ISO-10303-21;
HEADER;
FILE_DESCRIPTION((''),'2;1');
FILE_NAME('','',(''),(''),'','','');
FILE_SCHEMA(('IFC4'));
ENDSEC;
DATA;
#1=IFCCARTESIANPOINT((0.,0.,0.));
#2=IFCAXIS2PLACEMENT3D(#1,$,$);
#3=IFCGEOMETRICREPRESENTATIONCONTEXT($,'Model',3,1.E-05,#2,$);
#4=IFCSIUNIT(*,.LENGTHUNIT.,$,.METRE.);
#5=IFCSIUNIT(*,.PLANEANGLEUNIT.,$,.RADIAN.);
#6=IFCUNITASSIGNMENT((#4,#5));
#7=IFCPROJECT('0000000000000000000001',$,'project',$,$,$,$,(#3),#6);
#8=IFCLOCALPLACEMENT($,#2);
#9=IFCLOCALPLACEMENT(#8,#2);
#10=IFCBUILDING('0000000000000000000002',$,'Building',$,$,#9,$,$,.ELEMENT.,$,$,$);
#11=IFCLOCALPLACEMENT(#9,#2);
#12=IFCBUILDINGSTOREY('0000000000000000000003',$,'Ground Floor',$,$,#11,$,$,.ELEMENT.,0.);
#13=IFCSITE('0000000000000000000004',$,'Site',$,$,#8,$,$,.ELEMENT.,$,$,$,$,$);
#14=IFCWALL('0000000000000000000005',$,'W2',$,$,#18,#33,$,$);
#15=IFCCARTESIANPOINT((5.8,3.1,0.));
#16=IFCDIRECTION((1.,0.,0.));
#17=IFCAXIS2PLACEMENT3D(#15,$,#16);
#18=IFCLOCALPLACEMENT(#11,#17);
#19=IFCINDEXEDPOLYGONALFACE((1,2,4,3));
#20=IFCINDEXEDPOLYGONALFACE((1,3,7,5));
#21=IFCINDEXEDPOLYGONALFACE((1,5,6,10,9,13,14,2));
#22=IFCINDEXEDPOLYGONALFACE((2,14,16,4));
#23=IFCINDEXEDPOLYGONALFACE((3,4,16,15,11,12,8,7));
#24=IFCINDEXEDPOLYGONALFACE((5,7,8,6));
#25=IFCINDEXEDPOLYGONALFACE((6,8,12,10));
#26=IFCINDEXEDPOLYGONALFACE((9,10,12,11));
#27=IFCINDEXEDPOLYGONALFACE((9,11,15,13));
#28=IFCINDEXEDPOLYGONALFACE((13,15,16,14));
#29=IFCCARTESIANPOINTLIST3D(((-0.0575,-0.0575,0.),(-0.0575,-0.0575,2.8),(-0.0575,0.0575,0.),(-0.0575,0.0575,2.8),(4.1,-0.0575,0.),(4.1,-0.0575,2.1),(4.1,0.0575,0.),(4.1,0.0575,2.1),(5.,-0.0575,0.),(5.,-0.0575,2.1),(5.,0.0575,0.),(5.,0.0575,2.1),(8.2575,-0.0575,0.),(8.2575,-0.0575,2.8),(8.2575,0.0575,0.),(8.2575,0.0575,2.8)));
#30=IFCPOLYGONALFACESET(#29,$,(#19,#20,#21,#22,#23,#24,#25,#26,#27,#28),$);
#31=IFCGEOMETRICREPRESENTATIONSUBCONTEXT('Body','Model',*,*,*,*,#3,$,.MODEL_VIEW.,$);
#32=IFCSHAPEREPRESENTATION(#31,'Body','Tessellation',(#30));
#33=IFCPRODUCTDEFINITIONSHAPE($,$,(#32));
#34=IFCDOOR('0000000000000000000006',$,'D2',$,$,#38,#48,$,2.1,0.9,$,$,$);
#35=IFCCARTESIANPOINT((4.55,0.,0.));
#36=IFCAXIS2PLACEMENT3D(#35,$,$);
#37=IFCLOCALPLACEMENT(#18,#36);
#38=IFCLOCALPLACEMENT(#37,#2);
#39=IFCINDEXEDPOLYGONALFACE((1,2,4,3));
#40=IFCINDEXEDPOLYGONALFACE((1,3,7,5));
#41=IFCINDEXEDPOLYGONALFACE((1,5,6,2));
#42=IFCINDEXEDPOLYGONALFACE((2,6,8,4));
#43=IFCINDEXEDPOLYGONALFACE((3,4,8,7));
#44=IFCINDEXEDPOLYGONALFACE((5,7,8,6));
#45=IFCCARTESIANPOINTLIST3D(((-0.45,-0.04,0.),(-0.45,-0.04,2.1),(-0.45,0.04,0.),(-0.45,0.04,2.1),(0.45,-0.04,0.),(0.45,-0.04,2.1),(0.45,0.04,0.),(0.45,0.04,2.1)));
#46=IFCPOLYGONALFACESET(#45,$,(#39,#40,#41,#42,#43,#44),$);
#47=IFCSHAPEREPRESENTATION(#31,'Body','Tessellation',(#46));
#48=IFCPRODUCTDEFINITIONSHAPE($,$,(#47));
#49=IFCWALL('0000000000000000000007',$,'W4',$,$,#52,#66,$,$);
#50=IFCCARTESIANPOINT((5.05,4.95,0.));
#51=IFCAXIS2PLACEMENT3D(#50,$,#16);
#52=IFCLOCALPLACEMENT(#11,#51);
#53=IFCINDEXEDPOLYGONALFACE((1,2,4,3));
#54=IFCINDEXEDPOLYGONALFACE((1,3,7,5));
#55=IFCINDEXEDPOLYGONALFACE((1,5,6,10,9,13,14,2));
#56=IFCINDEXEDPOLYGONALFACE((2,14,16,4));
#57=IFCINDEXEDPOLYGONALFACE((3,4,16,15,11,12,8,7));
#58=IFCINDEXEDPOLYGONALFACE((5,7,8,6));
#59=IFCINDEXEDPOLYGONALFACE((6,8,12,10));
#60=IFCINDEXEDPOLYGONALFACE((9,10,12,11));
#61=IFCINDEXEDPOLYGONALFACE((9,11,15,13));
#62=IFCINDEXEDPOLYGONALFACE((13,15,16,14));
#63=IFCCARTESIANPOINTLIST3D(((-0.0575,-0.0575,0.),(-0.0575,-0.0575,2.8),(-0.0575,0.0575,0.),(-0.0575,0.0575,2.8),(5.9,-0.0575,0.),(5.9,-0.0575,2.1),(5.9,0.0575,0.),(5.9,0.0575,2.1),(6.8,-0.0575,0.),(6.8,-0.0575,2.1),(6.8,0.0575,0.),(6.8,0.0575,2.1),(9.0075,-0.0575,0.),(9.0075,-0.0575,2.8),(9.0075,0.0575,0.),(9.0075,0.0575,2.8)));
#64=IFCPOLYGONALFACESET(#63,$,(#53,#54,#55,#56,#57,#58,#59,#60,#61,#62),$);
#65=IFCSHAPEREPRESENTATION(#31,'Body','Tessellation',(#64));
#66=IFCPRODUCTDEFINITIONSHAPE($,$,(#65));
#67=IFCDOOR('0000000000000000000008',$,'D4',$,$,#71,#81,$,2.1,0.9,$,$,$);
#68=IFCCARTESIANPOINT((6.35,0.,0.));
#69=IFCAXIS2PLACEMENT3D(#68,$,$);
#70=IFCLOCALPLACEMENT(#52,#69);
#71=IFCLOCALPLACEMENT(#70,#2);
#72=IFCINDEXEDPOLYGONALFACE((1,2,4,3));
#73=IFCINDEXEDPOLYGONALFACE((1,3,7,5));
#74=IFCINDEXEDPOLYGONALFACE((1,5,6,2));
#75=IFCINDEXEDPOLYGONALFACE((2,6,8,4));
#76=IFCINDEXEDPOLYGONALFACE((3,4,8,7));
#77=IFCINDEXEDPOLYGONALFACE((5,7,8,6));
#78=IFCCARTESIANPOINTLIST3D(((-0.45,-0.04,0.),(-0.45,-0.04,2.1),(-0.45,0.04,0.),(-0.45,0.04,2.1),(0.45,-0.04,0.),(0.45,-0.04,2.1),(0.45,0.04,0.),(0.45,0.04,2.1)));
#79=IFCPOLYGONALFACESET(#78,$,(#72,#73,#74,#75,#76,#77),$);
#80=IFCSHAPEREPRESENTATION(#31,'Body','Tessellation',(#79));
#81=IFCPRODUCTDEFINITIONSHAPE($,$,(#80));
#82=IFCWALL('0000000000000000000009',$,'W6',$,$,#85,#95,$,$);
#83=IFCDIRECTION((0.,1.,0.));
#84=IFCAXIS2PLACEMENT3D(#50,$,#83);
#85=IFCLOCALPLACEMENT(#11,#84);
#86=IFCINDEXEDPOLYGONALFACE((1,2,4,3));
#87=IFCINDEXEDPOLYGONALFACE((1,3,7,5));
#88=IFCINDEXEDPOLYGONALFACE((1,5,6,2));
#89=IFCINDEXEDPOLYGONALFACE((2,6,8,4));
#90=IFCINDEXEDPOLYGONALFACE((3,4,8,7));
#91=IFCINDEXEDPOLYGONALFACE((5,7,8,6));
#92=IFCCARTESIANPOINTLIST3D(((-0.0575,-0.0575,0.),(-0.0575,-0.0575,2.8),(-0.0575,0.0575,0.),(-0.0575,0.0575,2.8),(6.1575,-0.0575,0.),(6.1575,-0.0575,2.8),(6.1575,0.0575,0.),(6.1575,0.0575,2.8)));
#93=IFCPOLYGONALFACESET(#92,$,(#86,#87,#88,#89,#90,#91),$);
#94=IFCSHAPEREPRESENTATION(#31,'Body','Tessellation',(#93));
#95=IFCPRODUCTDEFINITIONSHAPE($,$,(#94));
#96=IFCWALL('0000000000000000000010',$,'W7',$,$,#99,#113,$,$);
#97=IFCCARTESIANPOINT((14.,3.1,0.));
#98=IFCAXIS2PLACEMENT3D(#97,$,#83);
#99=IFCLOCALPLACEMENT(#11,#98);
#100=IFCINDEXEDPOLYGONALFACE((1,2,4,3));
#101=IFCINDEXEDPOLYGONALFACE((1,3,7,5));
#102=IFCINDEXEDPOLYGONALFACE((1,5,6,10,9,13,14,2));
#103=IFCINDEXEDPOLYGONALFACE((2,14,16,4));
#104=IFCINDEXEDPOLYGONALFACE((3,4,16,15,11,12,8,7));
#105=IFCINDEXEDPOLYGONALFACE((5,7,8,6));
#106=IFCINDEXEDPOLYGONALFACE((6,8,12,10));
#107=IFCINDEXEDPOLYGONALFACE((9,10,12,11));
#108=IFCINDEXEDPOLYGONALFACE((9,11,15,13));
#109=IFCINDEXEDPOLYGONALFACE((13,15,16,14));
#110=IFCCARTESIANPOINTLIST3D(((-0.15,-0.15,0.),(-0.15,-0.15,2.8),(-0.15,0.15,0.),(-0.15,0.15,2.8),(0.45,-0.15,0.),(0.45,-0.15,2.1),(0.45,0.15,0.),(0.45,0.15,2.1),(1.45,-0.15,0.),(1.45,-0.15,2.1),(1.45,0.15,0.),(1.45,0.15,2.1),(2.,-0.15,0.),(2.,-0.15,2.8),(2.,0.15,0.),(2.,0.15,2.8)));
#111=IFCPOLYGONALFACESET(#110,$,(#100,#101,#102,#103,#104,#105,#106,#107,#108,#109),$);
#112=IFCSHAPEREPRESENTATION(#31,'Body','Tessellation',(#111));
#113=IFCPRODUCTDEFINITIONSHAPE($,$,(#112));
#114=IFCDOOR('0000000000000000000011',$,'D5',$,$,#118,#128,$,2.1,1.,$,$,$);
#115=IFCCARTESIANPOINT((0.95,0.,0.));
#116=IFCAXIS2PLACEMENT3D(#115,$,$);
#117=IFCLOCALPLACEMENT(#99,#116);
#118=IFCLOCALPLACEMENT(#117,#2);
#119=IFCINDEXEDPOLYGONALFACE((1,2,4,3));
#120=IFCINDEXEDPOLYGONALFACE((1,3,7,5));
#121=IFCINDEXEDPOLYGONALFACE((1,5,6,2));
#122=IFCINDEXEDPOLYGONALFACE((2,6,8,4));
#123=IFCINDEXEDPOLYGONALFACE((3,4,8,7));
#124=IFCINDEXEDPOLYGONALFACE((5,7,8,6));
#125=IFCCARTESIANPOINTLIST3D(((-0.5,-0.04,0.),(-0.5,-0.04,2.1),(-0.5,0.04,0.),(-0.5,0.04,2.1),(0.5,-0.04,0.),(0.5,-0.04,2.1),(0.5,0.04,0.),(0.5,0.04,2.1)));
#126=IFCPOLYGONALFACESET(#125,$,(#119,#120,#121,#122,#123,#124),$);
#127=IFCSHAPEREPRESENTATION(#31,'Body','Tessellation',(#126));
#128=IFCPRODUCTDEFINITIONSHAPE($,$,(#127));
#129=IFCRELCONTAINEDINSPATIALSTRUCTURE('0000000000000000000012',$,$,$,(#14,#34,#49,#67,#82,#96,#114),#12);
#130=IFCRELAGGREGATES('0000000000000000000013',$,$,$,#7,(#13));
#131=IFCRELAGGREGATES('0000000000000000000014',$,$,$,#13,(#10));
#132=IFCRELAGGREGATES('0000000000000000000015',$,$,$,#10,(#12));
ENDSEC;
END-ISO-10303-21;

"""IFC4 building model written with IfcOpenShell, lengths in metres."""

from ifc_helpers import new_model, si_unit, frame, frame_2d, origin, origin_2d, place, context, subcontext, project, spatial, rectangle, extrude, element, fill, save


model = new_model("IFC4")

# Units and contexts
model_context = context("Model", 3, precision=1e-05, world=origin())
body_context = subcontext(model_context, "Body", "Model", "MODEL_VIEW")
ifc_project = project(units=[si_unit("LENGTHUNIT", "METRE"), si_unit("PLANEANGLEUNIT", "RADIAN")], contexts=[model_context])

# Site, building, storey
site_placement = place(None, origin())
site = spatial("IfcSite", under=ifc_project, at=site_placement, Name="Site", CompositionType="ELEMENT")
building_placement = place(site_placement, origin())
building = spatial("IfcBuilding", under=site, at=building_placement, Name="Building", CompositionType="ELEMENT")
storey_placement = place(building_placement, origin())
storey = spatial("IfcBuildingStorey", under=building, at=storey_placement, Name="Ground Floor", CompositionType="ELEMENT", Elevation=0.0)

# Walls, openings, doors
wall_1_placement = place(storey_placement, frame((5.8, 3.1, 0.0), x_axis=(1.0, 0.0, 0.0)))
wall_1 = element("IfcWall", 1, at=wall_1_placement, inside=storey, Name="W2", context=body_context, shape_type="SweptSolid", body=[
    extrude(rectangle(XDim=8.315, YDim=0.115, at=frame_2d((4.1, 0.0))), origin(), (0.0, 0.0, 1.0), 2.8),
])
opening_1_placement = place(wall_1_placement, frame((4.55, 0.0, 0.0)))
opening_1 = element("IfcOpeningElement", 2, at=opening_1_placement, cuts=wall_1, context=body_context, shape_type="SweptSolid", body=[
    extrude(rectangle(XDim=0.9, YDim=0.215, at=origin_2d()), origin(), (0.0, 0.0, 1.0), 2.1),
])
door_1_placement = place(opening_1_placement, origin())
door_1 = element("IfcDoor", 3, at=door_1_placement, inside=storey, Name="D2", OverallHeight=2.1, OverallWidth=0.9, context=body_context, shape_type="SweptSolid", body=[
    extrude(rectangle(XDim=0.9, YDim=0.08, at=origin_2d()), origin(), (0.0, 0.0, 1.0), 2.1),
])
fill(opening_1, door_1)
wall_2_placement = place(storey_placement, frame((5.05, 4.95, 0.0), x_axis=(1.0, 0.0, 0.0)))
wall_2 = element("IfcWall", 4, at=wall_2_placement, inside=storey, Name="W4", context=body_context, shape_type="SweptSolid", body=[
    extrude(rectangle(XDim=9.065, YDim=0.115, at=frame_2d((4.475, 0.0))), origin(), (0.0, 0.0, 1.0), 2.8),
])
opening_2_placement = place(wall_2_placement, frame((6.35, 0.0, 0.0)))
opening_2 = element("IfcOpeningElement", 5, at=opening_2_placement, cuts=wall_2, context=body_context, shape_type="SweptSolid", body=[
    extrude(rectangle(XDim=0.9, YDim=0.215, at=origin_2d()), origin(), (0.0, 0.0, 1.0), 2.1),
])
door_2_placement = place(opening_2_placement, origin())
door_2 = element("IfcDoor", 6, at=door_2_placement, inside=storey, Name="D4", OverallHeight=2.1, OverallWidth=0.9, context=body_context, shape_type="SweptSolid", body=[
    extrude(rectangle(XDim=0.9, YDim=0.08, at=origin_2d()), origin(), (0.0, 0.0, 1.0), 2.1),
])
fill(opening_2, door_2)

# Wall
wall_3_placement = place(storey_placement, frame((5.05, 4.95, 0.0), x_axis=(0.0, 1.0, 0.0)))
element("IfcWall", 7, at=wall_3_placement, inside=storey, Name="W6", context=body_context, shape_type="SweptSolid", body=[
    extrude(rectangle(XDim=6.215, YDim=0.115, at=frame_2d((3.05, 0.0))), origin(), (0.0, 0.0, 1.0), 2.8),
])

# Wall, opening, door
wall_4_placement = place(storey_placement, frame((14.0, 3.1, 0.0), x_axis=(0.0, 1.0, 0.0)))
wall_4 = element("IfcWall", 8, at=wall_4_placement, inside=storey, Name="W7", context=body_context, shape_type="SweptSolid", body=[
    extrude(rectangle(XDim=2.15, YDim=0.3, at=frame_2d((0.925, 0.0))), origin(), (0.0, 0.0, 1.0), 2.8),
])
opening_3_placement = place(wall_4_placement, frame((0.95, 0.0, 0.0)))
opening_3 = element("IfcOpeningElement", 9, at=opening_3_placement, cuts=wall_4, context=body_context, shape_type="SweptSolid", body=[
    extrude(rectangle(XDim=1.0, YDim=0.4, at=origin_2d()), origin(), (0.0, 0.0, 1.0), 2.1),
])
door_3_placement = place(opening_3_placement, origin())
door_3 = element("IfcDoor", 10, at=door_3_placement, inside=storey, Name="D5", OverallHeight=2.1, OverallWidth=1.0, context=body_context, shape_type="SweptSolid", body=[
    extrude(rectangle(XDim=1.0, YDim=0.08, at=origin_2d()), origin(), (0.0, 0.0, 1.0), 2.1),
])
fill(opening_3, door_3)

save(model, "model.ifc")
